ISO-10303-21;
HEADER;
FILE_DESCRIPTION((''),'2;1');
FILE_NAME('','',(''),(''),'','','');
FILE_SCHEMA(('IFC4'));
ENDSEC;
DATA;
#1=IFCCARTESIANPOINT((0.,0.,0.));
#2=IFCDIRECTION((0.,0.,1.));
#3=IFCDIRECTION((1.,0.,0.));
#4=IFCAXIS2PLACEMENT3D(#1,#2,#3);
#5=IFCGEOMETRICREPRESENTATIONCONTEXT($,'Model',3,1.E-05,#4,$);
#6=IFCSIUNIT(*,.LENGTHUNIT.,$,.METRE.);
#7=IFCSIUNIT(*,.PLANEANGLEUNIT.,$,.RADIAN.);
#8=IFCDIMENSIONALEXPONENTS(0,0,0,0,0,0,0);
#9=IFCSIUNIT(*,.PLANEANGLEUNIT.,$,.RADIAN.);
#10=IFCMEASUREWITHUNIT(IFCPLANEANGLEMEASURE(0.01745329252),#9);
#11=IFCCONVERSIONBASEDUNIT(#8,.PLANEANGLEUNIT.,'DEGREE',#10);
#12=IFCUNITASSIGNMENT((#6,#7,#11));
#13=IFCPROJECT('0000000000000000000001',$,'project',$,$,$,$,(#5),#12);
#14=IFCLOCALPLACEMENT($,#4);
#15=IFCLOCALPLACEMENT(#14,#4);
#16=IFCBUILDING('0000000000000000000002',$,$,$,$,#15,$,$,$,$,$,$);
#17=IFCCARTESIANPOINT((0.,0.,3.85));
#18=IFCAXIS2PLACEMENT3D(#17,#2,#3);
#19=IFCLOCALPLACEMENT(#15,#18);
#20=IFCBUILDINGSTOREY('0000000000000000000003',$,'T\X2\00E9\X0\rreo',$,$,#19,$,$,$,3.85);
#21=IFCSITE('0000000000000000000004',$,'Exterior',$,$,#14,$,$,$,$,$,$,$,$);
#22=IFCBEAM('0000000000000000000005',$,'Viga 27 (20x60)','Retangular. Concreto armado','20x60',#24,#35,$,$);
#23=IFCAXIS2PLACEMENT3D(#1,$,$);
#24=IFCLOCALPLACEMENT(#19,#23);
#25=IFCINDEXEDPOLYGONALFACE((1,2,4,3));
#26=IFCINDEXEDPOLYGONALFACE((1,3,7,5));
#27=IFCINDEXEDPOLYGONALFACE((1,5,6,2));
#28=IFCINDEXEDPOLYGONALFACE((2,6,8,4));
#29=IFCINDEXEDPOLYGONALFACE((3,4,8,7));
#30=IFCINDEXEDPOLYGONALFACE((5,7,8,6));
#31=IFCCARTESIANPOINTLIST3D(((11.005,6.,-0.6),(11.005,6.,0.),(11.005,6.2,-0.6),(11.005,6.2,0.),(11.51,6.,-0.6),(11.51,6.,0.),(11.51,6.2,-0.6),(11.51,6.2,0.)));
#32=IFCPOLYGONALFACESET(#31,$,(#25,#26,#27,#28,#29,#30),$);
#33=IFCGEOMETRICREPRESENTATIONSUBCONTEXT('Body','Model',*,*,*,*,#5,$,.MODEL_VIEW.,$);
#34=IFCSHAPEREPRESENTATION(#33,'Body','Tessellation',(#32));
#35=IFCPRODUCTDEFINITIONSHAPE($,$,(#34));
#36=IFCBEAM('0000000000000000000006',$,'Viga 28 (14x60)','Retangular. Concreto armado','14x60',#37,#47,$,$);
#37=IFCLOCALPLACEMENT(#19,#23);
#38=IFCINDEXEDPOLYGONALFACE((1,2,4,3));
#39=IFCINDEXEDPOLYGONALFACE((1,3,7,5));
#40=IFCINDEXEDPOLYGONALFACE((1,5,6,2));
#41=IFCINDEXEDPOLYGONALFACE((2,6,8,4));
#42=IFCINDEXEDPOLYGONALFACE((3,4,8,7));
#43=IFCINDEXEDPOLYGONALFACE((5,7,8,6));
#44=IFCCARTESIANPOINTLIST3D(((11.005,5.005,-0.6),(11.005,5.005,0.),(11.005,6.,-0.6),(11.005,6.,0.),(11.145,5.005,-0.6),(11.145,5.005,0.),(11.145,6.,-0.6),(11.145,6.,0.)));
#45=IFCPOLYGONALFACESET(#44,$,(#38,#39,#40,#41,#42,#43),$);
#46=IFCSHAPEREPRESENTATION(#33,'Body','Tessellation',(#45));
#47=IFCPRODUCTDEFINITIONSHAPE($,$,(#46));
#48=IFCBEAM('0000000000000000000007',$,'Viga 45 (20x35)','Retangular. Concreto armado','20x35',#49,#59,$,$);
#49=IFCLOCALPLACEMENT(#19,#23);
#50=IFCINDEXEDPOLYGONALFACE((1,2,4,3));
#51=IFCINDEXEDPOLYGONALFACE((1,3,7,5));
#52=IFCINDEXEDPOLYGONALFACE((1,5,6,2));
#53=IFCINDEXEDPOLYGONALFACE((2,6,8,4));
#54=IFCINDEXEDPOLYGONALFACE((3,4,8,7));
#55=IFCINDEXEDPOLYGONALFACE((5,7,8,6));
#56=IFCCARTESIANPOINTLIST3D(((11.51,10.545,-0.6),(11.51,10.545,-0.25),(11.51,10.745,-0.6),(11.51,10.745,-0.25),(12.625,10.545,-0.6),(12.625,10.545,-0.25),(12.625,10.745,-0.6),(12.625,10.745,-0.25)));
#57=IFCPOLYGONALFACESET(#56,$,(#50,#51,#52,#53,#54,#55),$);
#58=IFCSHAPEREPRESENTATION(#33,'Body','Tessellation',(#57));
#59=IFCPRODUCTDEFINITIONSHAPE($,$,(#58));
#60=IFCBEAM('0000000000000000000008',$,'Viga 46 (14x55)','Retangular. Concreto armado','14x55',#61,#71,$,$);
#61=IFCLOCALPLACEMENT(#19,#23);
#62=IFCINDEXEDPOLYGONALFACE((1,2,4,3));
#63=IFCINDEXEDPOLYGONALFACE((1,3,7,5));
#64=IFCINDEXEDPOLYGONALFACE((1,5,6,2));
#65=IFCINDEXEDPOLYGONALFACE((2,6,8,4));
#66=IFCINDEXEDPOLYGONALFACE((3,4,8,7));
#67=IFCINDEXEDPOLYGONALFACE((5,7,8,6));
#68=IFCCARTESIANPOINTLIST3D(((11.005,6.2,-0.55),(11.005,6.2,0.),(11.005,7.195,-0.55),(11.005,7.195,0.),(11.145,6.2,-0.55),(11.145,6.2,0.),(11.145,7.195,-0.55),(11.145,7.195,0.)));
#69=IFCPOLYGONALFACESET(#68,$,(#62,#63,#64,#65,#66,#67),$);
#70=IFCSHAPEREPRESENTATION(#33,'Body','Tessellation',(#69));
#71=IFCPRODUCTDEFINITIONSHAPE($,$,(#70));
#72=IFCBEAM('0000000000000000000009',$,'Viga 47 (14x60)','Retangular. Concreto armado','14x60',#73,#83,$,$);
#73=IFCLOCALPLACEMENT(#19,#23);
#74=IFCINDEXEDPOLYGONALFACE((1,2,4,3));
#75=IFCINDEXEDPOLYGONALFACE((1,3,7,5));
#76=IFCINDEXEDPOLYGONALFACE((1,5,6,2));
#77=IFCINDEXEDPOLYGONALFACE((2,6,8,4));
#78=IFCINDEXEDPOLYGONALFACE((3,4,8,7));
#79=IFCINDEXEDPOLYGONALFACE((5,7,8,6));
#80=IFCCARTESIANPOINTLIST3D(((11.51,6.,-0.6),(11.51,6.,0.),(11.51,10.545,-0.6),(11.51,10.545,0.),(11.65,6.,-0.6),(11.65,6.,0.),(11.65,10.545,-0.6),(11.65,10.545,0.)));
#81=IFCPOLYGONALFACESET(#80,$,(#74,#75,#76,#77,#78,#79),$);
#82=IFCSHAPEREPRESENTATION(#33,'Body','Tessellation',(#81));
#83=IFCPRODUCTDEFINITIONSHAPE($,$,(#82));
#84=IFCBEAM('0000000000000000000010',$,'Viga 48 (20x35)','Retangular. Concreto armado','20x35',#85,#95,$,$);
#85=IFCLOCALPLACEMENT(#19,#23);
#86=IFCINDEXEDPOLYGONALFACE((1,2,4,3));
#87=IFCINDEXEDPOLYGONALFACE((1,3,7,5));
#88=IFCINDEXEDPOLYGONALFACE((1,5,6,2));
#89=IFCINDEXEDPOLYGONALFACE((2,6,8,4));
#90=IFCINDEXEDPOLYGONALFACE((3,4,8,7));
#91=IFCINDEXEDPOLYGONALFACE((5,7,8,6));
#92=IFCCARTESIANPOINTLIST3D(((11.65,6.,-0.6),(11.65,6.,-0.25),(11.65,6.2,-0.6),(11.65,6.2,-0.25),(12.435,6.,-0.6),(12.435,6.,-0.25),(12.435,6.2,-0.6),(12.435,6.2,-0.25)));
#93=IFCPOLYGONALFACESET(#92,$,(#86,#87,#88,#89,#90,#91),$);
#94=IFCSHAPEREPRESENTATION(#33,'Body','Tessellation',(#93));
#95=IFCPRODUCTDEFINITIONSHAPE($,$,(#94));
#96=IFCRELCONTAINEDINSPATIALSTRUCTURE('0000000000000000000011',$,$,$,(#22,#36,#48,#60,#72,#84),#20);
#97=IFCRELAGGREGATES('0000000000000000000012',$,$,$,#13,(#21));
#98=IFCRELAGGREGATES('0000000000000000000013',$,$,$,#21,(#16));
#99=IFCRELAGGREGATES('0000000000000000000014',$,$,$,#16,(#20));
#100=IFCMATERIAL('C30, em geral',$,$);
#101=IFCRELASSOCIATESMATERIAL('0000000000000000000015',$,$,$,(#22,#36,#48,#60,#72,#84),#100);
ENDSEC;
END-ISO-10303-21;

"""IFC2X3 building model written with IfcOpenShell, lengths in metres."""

from ifc_helpers import new_model, entity, si_unit, converted_unit, frame, frame_2d, origin_with_axes, place, context, subcontext, project, spatial, rectangle, extrude, material, element, save


model = new_model("IFC2X3")

# Units and contexts
model_context = context("Model", 3, precision=1e-05, world=origin_with_axes())
body_context = subcontext(model_context, "Body", "Model", "MODEL_VIEW")
ifc_project = project(units=[si_unit("LENGTHUNIT", "METRE"), si_unit("PLANEANGLEUNIT", "RADIAN"), converted_unit("PLANEANGLEUNIT", "DEGREE", entity("IfcPlaneAngleMeasure", 0.01745329252), si_unit("PLANEANGLEUNIT", "RADIAN"), dimensions=[0, 0, 0, 0, 0, 0, 0])], contexts=[model_context])

# Site, building, storey
site_placement = place(None, origin_with_axes())
site = spatial("IfcSite", under=ifc_project, at=site_placement, Name="Exterior")
building_placement = place(site_placement, origin_with_axes())
building = spatial("IfcBuilding", under=site, at=building_placement)
storey_placement = place(building_placement, frame((0.0, 0.0, 3.85), z_axis=(0.0, 0.0, 1.0), x_axis=(1.0, 0.0, 0.0)))
storey = spatial("IfcBuildingStorey", under=building, at=storey_placement, Name="Térreo", Elevation=3.85)

# Beams
ifc_material_1 = material(Name="C30, em geral")
beam_1_placement = place(storey_placement, frame((11.005, 6.1, 0.0), z_axis=(1.0, 0.0, 0.0), x_axis=(0.0, 1.0, 0.0)))
element("IfcBeam", 1, at=beam_1_placement, inside=storey, material=ifc_material_1, Name="Viga 27 (20x60)", Description="Retangular. Concreto armado", ObjectType="20x60", context=body_context, shape_type="SweptSolid", body=[
    extrude(rectangle(XDim=0.2, YDim=0.6, at=frame_2d((0.0, -0.3), x_axis=(1.0, 0.0))), origin_with_axes(), (0.0, 0.0, 1.0), 0.505),
])
beam_2_placement = place(storey_placement, frame((11.075, 5.005, 0.0), z_axis=(0.0, 1.0, 0.0), x_axis=(-1.0, 0.0, 0.0)))
element("IfcBeam", 2, at=beam_2_placement, inside=storey, material=ifc_material_1, Name="Viga 28 (14x60)", Description="Retangular. Concreto armado", ObjectType="14x60", context=body_context, shape_type="SweptSolid", body=[
    extrude(rectangle(XDim=0.14, YDim=0.6, at=frame_2d((0.0, -0.3), x_axis=(1.0, 0.0))), origin_with_axes(), (0.0, 0.0, 1.0), 0.995),
])
beam_3_placement = place(storey_placement, frame((11.51, 10.645, -0.25), z_axis=(1.0, 0.0, 0.0), x_axis=(0.0, 1.0, 0.0)))
element("IfcBeam", 3, at=beam_3_placement, inside=storey, material=ifc_material_1, Name="Viga 45 (20x35)", Description="Retangular. Concreto armado", ObjectType="20x35", context=body_context, shape_type="SweptSolid", body=[
    extrude(rectangle(XDim=0.2, YDim=0.35, at=frame_2d((0.0, -0.175), x_axis=(1.0, 0.0))), origin_with_axes(), (0.0, 0.0, 1.0), 1.115),
])
beam_4_placement = place(storey_placement, frame((11.075, 6.2, 0.0), z_axis=(0.0, 1.0, 0.0), x_axis=(-1.0, 0.0, 0.0)))
element("IfcBeam", 4, at=beam_4_placement, inside=storey, material=ifc_material_1, Name="Viga 46 (14x55)", Description="Retangular. Concreto armado", ObjectType="14x55", context=body_context, shape_type="SweptSolid", body=[
    extrude(rectangle(XDim=0.14, YDim=0.55, at=frame_2d((0.0, -0.275), x_axis=(1.0, 0.0))), origin_with_axes(), (0.0, 0.0, 1.0), 0.995),
])
beam_5_placement = place(storey_placement, frame((11.58, 6.0, 0.0), z_axis=(0.0, 1.0, 0.0), x_axis=(-1.0, 0.0, 0.0)))
element("IfcBeam", 5, at=beam_5_placement, inside=storey, material=ifc_material_1, Name="Viga 47 (14x60)", Description="Retangular. Concreto armado", ObjectType="14x60", context=body_context, shape_type="SweptSolid", body=[
    extrude(rectangle(XDim=0.14, YDim=0.6, at=frame_2d((0.0, -0.3), x_axis=(1.0, 0.0))), origin_with_axes(), (0.0, 0.0, 1.0), 4.545),
])
beam_6_placement = place(storey_placement, frame((11.65, 6.1, -0.25), z_axis=(1.0, 0.0, 0.0), x_axis=(0.0, 1.0, 0.0)))
element("IfcBeam", 6, at=beam_6_placement, inside=storey, material=ifc_material_1, Name="Viga 48 (20x35)", Description="Retangular. Concreto armado", ObjectType="20x35", context=body_context, shape_type="SweptSolid", body=[
    extrude(rectangle(XDim=0.2, YDim=0.35, at=frame_2d((0.0, -0.175), x_axis=(1.0, 0.0))), origin_with_axes(), (0.0, 0.0, 1.0), 0.785),
])

save(model, "model.ifc")
